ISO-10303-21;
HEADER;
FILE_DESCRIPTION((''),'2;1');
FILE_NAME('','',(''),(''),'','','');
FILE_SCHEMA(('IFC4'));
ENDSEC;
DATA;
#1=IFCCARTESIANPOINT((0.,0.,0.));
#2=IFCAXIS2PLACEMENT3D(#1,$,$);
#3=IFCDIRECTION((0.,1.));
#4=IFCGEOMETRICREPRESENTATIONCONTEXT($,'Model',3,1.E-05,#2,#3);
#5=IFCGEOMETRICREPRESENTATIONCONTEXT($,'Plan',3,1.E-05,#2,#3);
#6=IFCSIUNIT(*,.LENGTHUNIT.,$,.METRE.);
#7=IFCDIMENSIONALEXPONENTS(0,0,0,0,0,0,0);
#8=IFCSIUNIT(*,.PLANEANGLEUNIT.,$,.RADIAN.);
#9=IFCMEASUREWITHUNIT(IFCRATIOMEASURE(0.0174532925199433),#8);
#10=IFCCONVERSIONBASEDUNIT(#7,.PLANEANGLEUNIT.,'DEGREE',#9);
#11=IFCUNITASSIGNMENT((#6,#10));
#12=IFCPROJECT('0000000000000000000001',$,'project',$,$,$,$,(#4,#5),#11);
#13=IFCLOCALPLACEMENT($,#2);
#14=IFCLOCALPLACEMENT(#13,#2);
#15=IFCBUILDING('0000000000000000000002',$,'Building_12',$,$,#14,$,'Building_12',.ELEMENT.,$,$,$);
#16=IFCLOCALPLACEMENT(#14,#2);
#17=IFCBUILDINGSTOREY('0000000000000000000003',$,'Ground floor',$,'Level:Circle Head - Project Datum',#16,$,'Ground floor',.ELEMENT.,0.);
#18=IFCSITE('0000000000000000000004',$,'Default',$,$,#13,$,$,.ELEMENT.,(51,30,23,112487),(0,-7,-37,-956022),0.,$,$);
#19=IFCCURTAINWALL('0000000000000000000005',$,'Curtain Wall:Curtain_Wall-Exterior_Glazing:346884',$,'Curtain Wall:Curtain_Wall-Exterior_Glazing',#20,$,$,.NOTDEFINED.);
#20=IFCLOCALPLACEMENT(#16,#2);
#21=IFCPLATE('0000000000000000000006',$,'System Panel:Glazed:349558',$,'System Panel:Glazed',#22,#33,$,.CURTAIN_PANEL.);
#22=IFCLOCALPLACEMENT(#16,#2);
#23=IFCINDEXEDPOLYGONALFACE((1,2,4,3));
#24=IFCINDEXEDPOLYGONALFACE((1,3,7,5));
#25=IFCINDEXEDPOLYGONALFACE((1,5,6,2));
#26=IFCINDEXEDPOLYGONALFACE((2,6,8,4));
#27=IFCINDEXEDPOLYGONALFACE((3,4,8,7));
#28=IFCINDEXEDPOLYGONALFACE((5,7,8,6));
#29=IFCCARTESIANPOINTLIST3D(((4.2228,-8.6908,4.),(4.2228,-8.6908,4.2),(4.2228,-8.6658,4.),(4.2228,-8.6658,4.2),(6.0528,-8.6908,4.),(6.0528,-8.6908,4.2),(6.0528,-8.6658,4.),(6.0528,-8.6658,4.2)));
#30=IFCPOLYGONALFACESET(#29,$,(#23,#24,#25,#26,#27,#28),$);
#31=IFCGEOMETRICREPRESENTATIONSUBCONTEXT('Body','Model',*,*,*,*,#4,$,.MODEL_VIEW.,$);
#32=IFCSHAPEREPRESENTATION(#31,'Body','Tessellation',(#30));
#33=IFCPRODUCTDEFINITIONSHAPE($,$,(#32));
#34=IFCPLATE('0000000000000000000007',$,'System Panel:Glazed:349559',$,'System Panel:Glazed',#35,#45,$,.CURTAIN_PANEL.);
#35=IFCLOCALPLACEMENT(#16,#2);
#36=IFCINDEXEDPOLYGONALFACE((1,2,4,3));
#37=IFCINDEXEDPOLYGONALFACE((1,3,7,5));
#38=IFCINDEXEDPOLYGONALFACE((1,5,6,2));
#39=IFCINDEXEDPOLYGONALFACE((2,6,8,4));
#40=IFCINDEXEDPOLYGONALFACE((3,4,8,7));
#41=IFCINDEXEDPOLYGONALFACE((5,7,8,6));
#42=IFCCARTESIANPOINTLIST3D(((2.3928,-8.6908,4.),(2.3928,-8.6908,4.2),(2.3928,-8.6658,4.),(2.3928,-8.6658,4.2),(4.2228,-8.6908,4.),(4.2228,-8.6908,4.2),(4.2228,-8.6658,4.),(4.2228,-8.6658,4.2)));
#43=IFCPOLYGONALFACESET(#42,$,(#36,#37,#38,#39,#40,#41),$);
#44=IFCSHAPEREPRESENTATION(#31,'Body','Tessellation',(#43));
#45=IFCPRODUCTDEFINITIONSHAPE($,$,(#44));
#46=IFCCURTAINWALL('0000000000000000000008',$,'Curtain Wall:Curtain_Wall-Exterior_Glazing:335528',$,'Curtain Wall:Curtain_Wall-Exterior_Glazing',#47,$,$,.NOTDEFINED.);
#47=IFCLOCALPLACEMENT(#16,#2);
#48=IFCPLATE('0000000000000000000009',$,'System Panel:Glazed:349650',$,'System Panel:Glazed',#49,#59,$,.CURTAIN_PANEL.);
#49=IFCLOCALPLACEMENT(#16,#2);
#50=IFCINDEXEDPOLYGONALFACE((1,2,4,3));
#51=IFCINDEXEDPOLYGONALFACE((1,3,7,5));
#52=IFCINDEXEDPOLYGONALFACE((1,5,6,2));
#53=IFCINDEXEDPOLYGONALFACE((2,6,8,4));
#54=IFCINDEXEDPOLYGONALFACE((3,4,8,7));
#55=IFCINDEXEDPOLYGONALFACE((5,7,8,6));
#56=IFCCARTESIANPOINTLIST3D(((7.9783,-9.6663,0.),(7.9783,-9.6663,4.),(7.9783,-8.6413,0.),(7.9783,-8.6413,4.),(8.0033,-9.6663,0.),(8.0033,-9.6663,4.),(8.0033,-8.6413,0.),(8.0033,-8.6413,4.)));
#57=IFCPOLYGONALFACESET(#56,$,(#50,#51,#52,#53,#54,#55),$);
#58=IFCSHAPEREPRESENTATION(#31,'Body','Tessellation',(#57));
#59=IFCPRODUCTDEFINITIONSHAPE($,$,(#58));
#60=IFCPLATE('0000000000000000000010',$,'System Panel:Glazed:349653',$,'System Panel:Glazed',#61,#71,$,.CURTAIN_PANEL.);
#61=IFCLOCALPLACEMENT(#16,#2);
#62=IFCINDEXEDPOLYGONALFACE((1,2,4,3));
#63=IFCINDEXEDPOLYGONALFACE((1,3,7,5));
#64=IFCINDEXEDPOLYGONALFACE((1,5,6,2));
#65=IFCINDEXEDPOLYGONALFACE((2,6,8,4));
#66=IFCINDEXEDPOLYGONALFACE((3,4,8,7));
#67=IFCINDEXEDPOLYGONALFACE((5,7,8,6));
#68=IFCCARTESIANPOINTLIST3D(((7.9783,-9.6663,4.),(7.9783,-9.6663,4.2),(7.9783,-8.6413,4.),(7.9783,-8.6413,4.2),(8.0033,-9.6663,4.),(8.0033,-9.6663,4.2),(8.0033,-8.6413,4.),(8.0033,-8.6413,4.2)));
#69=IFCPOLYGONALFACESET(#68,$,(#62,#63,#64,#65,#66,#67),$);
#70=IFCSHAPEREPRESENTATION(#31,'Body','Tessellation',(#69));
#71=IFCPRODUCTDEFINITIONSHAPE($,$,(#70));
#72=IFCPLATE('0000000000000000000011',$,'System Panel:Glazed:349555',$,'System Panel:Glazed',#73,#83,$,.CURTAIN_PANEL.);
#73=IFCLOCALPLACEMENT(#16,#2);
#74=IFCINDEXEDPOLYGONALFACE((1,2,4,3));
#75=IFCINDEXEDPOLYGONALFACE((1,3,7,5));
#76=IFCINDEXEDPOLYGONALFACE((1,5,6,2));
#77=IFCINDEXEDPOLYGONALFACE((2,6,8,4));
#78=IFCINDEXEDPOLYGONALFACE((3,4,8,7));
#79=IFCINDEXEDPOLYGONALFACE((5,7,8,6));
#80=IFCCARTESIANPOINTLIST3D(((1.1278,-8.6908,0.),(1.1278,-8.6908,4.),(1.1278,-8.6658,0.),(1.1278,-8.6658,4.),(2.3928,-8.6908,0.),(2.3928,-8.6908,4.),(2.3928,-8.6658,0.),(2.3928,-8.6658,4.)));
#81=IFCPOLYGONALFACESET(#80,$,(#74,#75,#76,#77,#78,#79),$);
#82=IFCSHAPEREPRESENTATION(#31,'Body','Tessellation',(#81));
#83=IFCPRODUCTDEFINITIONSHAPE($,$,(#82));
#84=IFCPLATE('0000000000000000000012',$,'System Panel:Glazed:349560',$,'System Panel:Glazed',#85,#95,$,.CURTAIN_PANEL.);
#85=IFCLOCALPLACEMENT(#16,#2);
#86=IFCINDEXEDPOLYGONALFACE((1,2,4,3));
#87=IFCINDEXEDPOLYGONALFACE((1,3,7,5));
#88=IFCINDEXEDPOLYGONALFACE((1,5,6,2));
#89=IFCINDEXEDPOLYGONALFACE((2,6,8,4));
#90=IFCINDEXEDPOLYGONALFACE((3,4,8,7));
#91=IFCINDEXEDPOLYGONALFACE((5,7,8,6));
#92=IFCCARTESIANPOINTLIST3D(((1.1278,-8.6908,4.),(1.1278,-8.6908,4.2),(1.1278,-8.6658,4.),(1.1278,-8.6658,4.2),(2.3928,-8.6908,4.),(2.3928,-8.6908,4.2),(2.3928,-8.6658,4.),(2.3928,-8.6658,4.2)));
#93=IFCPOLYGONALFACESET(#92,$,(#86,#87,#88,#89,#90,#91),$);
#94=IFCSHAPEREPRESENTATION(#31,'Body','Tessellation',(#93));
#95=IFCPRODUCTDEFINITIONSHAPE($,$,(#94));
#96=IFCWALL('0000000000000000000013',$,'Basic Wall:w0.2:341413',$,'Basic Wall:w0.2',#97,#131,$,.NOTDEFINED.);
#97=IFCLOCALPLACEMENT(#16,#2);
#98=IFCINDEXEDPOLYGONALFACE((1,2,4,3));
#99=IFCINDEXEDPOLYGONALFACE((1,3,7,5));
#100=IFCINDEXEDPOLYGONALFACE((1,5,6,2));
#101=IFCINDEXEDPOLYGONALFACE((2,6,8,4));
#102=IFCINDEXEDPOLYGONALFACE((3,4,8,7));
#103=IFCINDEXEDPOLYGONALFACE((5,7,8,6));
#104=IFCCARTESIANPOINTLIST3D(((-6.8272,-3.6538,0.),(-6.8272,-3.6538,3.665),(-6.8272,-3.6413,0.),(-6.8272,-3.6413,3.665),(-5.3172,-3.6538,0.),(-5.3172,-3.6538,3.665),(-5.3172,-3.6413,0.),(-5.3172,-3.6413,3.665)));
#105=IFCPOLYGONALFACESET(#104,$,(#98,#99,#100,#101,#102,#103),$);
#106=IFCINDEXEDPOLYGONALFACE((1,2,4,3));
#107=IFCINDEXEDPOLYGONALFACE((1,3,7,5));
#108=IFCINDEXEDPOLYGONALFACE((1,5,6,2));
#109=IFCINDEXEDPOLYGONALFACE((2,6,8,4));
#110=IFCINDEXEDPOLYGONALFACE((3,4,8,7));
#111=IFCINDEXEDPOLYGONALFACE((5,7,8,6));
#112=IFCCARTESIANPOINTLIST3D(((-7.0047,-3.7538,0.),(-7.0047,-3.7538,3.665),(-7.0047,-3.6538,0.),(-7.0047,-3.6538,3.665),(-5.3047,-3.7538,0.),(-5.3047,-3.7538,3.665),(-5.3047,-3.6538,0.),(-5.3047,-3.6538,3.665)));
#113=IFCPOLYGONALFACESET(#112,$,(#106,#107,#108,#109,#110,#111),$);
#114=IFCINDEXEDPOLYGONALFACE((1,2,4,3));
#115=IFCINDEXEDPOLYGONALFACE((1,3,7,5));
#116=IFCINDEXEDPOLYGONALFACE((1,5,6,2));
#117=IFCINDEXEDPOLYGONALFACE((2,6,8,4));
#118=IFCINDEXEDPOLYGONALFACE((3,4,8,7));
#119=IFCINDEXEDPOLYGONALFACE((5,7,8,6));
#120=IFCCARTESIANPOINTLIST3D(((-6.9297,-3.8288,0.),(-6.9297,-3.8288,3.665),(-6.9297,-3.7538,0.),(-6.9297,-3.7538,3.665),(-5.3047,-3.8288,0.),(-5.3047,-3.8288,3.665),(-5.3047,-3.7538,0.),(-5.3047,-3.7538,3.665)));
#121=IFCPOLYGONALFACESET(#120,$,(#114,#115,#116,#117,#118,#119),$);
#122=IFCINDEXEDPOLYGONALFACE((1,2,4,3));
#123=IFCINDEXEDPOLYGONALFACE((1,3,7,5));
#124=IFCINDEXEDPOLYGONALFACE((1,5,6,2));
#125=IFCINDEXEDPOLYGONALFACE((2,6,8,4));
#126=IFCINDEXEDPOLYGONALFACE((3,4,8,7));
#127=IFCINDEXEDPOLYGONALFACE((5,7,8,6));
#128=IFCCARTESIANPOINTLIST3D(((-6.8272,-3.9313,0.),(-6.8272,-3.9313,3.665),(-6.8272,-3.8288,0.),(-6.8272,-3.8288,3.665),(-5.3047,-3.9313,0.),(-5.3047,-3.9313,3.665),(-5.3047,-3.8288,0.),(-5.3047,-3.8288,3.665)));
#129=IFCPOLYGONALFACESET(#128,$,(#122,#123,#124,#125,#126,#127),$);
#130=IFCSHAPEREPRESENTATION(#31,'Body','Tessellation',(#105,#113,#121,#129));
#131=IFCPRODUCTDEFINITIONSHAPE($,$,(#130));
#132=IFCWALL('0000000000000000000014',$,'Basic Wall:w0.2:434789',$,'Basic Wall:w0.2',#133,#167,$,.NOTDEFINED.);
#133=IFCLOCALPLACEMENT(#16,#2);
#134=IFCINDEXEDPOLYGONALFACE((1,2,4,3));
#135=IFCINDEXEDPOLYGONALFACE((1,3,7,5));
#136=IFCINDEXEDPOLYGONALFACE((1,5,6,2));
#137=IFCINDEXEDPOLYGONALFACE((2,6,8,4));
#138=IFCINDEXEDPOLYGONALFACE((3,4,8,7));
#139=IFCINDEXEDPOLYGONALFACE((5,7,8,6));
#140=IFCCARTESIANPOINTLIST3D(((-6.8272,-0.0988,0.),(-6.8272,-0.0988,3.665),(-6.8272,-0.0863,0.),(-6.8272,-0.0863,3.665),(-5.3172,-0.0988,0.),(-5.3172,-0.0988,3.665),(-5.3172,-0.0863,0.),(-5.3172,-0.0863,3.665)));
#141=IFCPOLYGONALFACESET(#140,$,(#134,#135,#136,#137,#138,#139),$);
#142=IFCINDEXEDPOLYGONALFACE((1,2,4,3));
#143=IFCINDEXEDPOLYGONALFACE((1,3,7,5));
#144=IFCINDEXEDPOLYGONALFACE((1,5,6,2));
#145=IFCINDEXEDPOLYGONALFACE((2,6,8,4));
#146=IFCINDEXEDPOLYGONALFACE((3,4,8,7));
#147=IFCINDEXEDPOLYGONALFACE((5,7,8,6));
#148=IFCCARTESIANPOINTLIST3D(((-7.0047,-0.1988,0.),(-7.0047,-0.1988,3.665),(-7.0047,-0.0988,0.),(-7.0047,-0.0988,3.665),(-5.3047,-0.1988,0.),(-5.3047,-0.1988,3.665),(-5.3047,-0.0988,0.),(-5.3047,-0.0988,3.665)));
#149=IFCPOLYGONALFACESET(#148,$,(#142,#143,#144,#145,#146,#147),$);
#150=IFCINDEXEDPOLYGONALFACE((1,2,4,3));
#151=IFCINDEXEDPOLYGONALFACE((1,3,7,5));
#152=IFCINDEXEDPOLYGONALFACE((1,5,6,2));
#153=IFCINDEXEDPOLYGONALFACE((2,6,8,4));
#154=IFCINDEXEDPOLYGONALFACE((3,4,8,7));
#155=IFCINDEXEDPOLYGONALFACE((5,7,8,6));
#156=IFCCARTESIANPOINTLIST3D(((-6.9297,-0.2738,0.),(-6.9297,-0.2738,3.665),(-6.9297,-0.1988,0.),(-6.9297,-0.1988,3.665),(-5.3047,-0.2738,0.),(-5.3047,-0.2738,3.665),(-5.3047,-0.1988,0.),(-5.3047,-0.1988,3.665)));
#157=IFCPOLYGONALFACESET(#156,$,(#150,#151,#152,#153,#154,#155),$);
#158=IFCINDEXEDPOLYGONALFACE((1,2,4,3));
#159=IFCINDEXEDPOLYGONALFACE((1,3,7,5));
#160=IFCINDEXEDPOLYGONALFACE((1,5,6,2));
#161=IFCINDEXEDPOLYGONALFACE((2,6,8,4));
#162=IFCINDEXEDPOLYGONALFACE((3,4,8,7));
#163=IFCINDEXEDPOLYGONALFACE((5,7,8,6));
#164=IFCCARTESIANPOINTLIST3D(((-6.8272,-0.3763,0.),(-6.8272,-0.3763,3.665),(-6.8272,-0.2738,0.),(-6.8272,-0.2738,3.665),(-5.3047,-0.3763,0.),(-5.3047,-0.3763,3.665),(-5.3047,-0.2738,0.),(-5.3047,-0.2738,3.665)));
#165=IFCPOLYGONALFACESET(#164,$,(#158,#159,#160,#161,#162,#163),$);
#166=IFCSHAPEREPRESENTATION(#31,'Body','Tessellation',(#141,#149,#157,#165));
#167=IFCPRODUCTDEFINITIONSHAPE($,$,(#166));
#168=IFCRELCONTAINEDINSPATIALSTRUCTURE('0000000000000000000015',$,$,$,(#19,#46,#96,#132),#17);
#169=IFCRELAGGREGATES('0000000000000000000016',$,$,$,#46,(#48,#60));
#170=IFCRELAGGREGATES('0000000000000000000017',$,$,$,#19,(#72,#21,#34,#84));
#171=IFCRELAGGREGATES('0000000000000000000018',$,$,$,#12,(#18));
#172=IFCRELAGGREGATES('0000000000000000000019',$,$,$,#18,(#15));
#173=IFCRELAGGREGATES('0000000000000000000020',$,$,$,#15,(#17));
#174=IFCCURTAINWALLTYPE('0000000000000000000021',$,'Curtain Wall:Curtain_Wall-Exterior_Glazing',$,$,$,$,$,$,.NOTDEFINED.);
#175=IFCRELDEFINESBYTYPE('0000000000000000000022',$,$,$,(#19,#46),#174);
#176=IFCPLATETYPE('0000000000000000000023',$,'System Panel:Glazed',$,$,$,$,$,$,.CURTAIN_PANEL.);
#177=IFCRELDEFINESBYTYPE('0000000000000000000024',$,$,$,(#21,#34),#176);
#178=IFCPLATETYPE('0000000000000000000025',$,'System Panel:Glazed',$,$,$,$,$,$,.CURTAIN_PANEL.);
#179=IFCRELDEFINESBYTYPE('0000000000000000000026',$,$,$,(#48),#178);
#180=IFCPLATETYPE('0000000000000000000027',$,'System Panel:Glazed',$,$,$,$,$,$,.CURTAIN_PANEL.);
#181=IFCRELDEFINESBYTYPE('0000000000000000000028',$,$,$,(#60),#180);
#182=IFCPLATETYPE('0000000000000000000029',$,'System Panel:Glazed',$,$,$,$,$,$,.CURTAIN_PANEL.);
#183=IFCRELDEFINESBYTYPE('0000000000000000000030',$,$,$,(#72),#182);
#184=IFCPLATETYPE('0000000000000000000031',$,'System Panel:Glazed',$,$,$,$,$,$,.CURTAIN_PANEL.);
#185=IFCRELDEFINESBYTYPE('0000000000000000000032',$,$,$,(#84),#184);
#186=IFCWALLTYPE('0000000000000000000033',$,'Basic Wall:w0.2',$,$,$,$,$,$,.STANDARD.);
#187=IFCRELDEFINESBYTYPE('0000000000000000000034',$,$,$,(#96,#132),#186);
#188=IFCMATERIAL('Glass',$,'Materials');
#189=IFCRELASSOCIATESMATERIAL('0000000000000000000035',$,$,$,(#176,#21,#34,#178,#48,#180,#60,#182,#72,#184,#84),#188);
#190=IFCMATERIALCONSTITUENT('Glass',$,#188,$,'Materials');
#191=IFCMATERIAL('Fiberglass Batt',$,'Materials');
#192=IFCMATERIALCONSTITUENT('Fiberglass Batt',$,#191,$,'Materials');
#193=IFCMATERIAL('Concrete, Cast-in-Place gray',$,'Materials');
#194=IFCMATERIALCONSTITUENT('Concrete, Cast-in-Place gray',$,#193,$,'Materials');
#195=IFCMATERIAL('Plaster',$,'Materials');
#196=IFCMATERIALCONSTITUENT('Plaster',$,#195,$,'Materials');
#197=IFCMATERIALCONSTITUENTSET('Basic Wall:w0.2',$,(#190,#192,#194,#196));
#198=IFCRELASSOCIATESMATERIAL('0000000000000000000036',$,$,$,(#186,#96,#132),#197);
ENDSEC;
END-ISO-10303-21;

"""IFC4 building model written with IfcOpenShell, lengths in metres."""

from ifc_helpers import new_model, entity, si_unit, converted_unit, direction, frame, origin, place, context, subcontext, project, spatial, indexed_curve, outline, extrude, source, transform, mapped, material, constituent, constituent_set, type_object, type_shapes, element, aggregate, save


model = new_model("IFC4")

# Units and contexts
model_context = context("Model", 3, precision=1e-05, world=origin(), true_north=direction((0.0, 1.0)))
plan_context = context("Plan", 3, precision=1e-05, world=origin(), true_north=direction((0.0, 1.0)))
body_context = subcontext(model_context, "Body", "Model", "MODEL_VIEW")
ifc_project = project(units=[si_unit("LENGTHUNIT", "METRE"), converted_unit("PLANEANGLEUNIT", "DEGREE", entity("IfcRatioMeasure", 0.0174532925199433), si_unit("PLANEANGLEUNIT", "RADIAN"), dimensions=[0, 0, 0, 0, 0, 0, 0])], contexts=[model_context, plan_context])

# Site, building, storey
site_placement = place(None, origin())
site = spatial("IfcSite", under=ifc_project, at=site_placement, Name="Default", CompositionType="ELEMENT", RefLatitude=(51, 30, 23, 112487), RefLongitude=(0, -7, -37, -956022), RefElevation=0.0)
building_placement = place(site_placement, origin())
building = spatial("IfcBuilding", under=site, at=building_placement, Name="Building_12", LongName="Building_12", CompositionType="ELEMENT")
storey_placement = place(building_placement, origin())
storey = spatial("IfcBuildingStorey", under=building, at=storey_placement, Name="Ground floor", ObjectType="Level:Circle Head - Project Datum", LongName="Ground floor", CompositionType="ELEMENT", Elevation=0.0)

# Shared definitions
ifc_material_1 = material(Name="Plaster", Category="Materials")
ifc_material_2 = material(Name="Glass", Category="Materials")

# Shared definitions
ifc_material_3 = material(Name="Concrete, Cast-in-Place gray", Category="Materials")

# Curtain walls, plates
curtain_wall_type = type_object("IfcCurtainWallType", Name="Curtain Wall:Curtain_Wall-Exterior_Glazing", PredefinedType="NOTDEFINED")
curtain_wall_1_placement = place(storey_placement, origin())
curtain_wall_1 = element("IfcCurtainWall", 1, at=curtain_wall_1_placement, inside=storey, type_object=curtain_wall_type, Name="Curtain Wall:Curtain_Wall-Exterior_Glazing:346884", ObjectType="Curtain Wall:Curtain_Wall-Exterior_Glazing", PredefinedType="NOTDEFINED")
plate_type_1 = type_object("IfcPlateType", Name="System Panel:Glazed", PredefinedType="CURTAIN_PANEL", material=ifc_material_2)
shared_shape_1 = source(origin(), body_context, "Body", "SweptSolid", [
    extrude(outline(indexed_curve([(-0.0125, -0.915), (0.0125, -0.915), (0.0125, 0.915), (-0.0125, 0.915), (-0.0125, -0.915)], self_intersect=False)), frame((0.0, 0.037, 0.0), z_axis=(0.0, 0.0, 1.0), x_axis=(0.0, 1.0, 0.0)), (0.0, 0.0, 1.0), 0.2),
])
type_shapes(plate_type_1, [shared_shape_1])
plate_1_placement = place(curtain_wall_1_placement, frame((5.1378, -8.6413, 4.0), z_axis=(0.0, 0.0, 1.0), x_axis=(-1.0, 0.0, 0.0)))
plate_1 = element("IfcPlate", 2, at=plate_1_placement, type_object=plate_type_1, material=ifc_material_2, Name="System Panel:Glazed:349558", ObjectType="System Panel:Glazed", PredefinedType="CURTAIN_PANEL", context=body_context, shape_type="MappedRepresentation", body=[
    mapped(shared_shape_1, transform((0.0, 0.0, 0.0), scale=1.0)),
])
plate_2_placement = place(curtain_wall_1_placement, frame((3.3078, -8.6413, 4.0), z_axis=(0.0, 0.0, 1.0), x_axis=(-1.0, 0.0, 0.0)))
plate_2 = element("IfcPlate", 3, at=plate_2_placement, type_object=plate_type_1, material=ifc_material_2, Name="System Panel:Glazed:349559", ObjectType="System Panel:Glazed", PredefinedType="CURTAIN_PANEL", context=body_context, shape_type="MappedRepresentation", body=[
    mapped(shared_shape_1, transform((0.0, 0.0, 0.0), scale=1.0)),
])
curtain_wall_2_placement = place(storey_placement, origin())
curtain_wall_2 = element("IfcCurtainWall", 4, at=curtain_wall_2_placement, inside=storey, type_object=curtain_wall_type, Name="Curtain Wall:Curtain_Wall-Exterior_Glazing:335528", ObjectType="Curtain Wall:Curtain_Wall-Exterior_Glazing", PredefinedType="NOTDEFINED")
plate_type_2 = type_object("IfcPlateType", Name="System Panel:Glazed", PredefinedType="CURTAIN_PANEL", material=ifc_material_2)
shared_shape_2 = source(origin(), body_context, "Body", "SweptSolid", [
    extrude(outline(indexed_curve([(-0.0125, -0.5125), (0.0125, -0.5125), (0.0125, 0.5125), (-0.0125, 0.5125), (-0.0125, -0.5125)], self_intersect=False)), frame((0.0, 0.037, 0.0), z_axis=(0.0, 0.0, 1.0), x_axis=(0.0, 1.0, 0.0)), (0.0, 0.0, 1.0), 4.0),
])
type_shapes(plate_type_2, [shared_shape_2])
plate_3_placement = place(curtain_wall_2_placement, frame((8.0278, -9.1538, 0.0), z_axis=(0.0, 0.0, 1.0), x_axis=(0.0, 1.0, 0.0)))
plate_3 = element("IfcPlate", 5, at=plate_3_placement, type_object=plate_type_2, material=ifc_material_2, Name="System Panel:Glazed:349650", ObjectType="System Panel:Glazed", PredefinedType="CURTAIN_PANEL", context=body_context, shape_type="MappedRepresentation", body=[
    mapped(shared_shape_2, transform((0.0, 0.0, 0.0), scale=1.0)),
])
plate_type_3 = type_object("IfcPlateType", Name="System Panel:Glazed", PredefinedType="CURTAIN_PANEL", material=ifc_material_2)
shared_shape_3 = source(origin(), body_context, "Body", "SweptSolid", [
    extrude(outline(indexed_curve([(-0.0125, -0.5125), (0.0125, -0.5125), (0.0125, 0.5125), (-0.0125, 0.5125), (-0.0125, -0.5125)], self_intersect=False)), frame((0.0, 0.037, 0.0), z_axis=(0.0, 0.0, 1.0), x_axis=(0.0, 1.0, 0.0)), (0.0, 0.0, 1.0), 0.2),
])
type_shapes(plate_type_3, [shared_shape_3])
plate_4_placement = place(curtain_wall_2_placement, frame((8.0278, -9.1538, 4.0), z_axis=(0.0, 0.0, 1.0), x_axis=(0.0, 1.0, 0.0)))
plate_4 = element("IfcPlate", 6, at=plate_4_placement, type_object=plate_type_3, material=ifc_material_2, Name="System Panel:Glazed:349653", ObjectType="System Panel:Glazed", PredefinedType="CURTAIN_PANEL", context=body_context, shape_type="MappedRepresentation", body=[
    mapped(shared_shape_3, transform((0.0, 0.0, 0.0), scale=1.0)),
])
aggregate(curtain_wall_2, [plate_3, plate_4])

# Plates
plate_type_4 = type_object("IfcPlateType", Name="System Panel:Glazed", PredefinedType="CURTAIN_PANEL", material=ifc_material_2)
shared_shape_4 = source(origin(), body_context, "Body", "SweptSolid", [
    extrude(outline(indexed_curve([(-0.0125, -0.6325), (0.0125, -0.6325), (0.0125, 0.6325), (-0.0125, 0.6325), (-0.0125, -0.6325)], self_intersect=False)), frame((0.0, 0.037, 0.0), z_axis=(0.0, 0.0, 1.0), x_axis=(0.0, 1.0, 0.0)), (0.0, 0.0, 1.0), 4.0),
])
type_shapes(plate_type_4, [shared_shape_4])
plate_5_placement = place(curtain_wall_1_placement, frame((1.7603, -8.6413, 0.0), z_axis=(0.0, 0.0, 1.0), x_axis=(-1.0, 0.0, 0.0)))
plate_5 = element("IfcPlate", 7, at=plate_5_placement, type_object=plate_type_4, material=ifc_material_2, Name="System Panel:Glazed:349555", ObjectType="System Panel:Glazed", PredefinedType="CURTAIN_PANEL", context=body_context, shape_type="MappedRepresentation", body=[
    mapped(shared_shape_4, transform((0.0, 0.0, 0.0), scale=1.0)),
])
plate_type_5 = type_object("IfcPlateType", Name="System Panel:Glazed", PredefinedType="CURTAIN_PANEL", material=ifc_material_2)
shared_shape_5 = source(origin(), body_context, "Body", "SweptSolid", [
    extrude(outline(indexed_curve([(-0.0125, -0.6325), (0.0125, -0.6325), (0.0125, 0.6325), (-0.0125, 0.6325), (-0.0125, -0.6325)], self_intersect=False)), frame((0.0, 0.037, 0.0), z_axis=(0.0, 0.0, 1.0), x_axis=(0.0, 1.0, 0.0)), (0.0, 0.0, 1.0), 0.2),
])
type_shapes(plate_type_5, [shared_shape_5])
plate_6_placement = place(curtain_wall_1_placement, frame((1.7603, -8.6413, 4.0), z_axis=(0.0, 0.0, 1.0), x_axis=(-1.0, 0.0, 0.0)))
plate_6 = element("IfcPlate", 8, at=plate_6_placement, type_object=plate_type_5, material=ifc_material_2, Name="System Panel:Glazed:349560", ObjectType="System Panel:Glazed", PredefinedType="CURTAIN_PANEL", context=body_context, shape_type="MappedRepresentation", body=[
    mapped(shared_shape_5, transform((0.0, 0.0, 0.0), scale=1.0)),
])
aggregate(curtain_wall_1, [plate_5, plate_1, plate_2, plate_6])

# Wall
ifc_constituent_1 = constituent(ifc_material_2, Name="Glass", Category="Materials")
ifc_material_4 = material(Name="Fiberglass Batt", Category="Materials")
ifc_constituent_2 = constituent(ifc_material_4, Name="Fiberglass Batt", Category="Materials")
ifc_constituent_3 = constituent(ifc_material_3, Name="Concrete, Cast-in-Place gray", Category="Materials")
ifc_constituent_4 = constituent(ifc_material_1, Name="Plaster", Category="Materials")
ifc_constituent_set_1 = constituent_set(constituents=[ifc_constituent_1, ifc_constituent_2, ifc_constituent_3, ifc_constituent_4], Name="Basic Wall:w0.2")
wall_type = type_object("IfcWallType", Name="Basic Wall:w0.2", PredefinedType="STANDARD", material=ifc_constituent_set_1)
wall_1_placement = place(storey_placement, frame((-5.3172, -3.7863, 0.0), z_axis=(0.0, 0.0, 1.0), x_axis=(-1.0, 0.0, 0.0)))
element("IfcWall", 9, at=wall_1_placement, inside=storey, type_object=wall_type, material=ifc_constituent_set_1, Name="Basic Wall:w0.2:341413", ObjectType="Basic Wall:w0.2", PredefinedType="NOTDEFINED", context=body_context, shape_type="SweptSolid", body=[
    extrude(outline(indexed_curve([(-0.0063, -0.755), (0.0062, -0.755), (0.0063, 0.755), (-0.0062, 0.755), (-0.0063, -0.755)], self_intersect=False)), frame((0.755, -0.1388, 0.0), z_axis=(0.0, 0.0, 1.0), x_axis=(0.0, 1.0, 0.0)), (0.0, 0.0, 1.0), 3.665),
    extrude(outline(indexed_curve([(-0.85, -0.05), (0.85, -0.05), (0.85, 0.05), (-0.85, 0.05), (-0.85, -0.05)], self_intersect=False)), frame((0.8375, -0.0825, 0.0)), (0.0, 0.0, 1.0), 3.665),
    extrude(outline(indexed_curve([(-0.8125, -0.0375), (0.8125, -0.0375), (0.8125, 0.0375), (-0.8125, 0.0375), (-0.8125, -0.0375)], self_intersect=False)), frame((0.8, 0.005, 0.0)), (0.0, 0.0, 1.0), 3.665),
    extrude(outline(indexed_curve([(-0.0513, -0.7612), (0.0512, -0.7612), (0.0513, 0.7612), (-0.0512, 0.7612), (-0.0513, -0.7612)], self_intersect=False)), frame((0.7487, 0.0938, 0.0), z_axis=(0.0, 0.0, 1.0), x_axis=(0.0, -1.0, 0.0)), (0.0, 0.0, 1.0), 3.665),
])

# Wall
wall_2_placement = place(storey_placement, frame((-5.3172, -0.2313, 0.0), z_axis=(0.0, 0.0, 1.0), x_axis=(-1.0, 0.0, 0.0)))
element("IfcWall", 10, at=wall_2_placement, inside=storey, type_object=wall_type, material=ifc_constituent_set_1, Name="Basic Wall:w0.2:434789", ObjectType="Basic Wall:w0.2", PredefinedType="NOTDEFINED", context=body_context, shape_type="SweptSolid", body=[
    extrude(outline(indexed_curve([(-0.0063, -0.755), (0.0062, -0.755), (0.0063, 0.755), (-0.0062, 0.755), (-0.0063, -0.755)], self_intersect=False)), frame((0.755, -0.1388, 0.0), z_axis=(0.0, 0.0, 1.0), x_axis=(0.0, 1.0, 0.0)), (0.0, 0.0, 1.0), 3.665),
    extrude(outline(indexed_curve([(-0.85, -0.05), (0.85, -0.05), (0.85, 0.05), (-0.85, 0.05), (-0.85, -0.05)], self_intersect=False)), frame((0.8375, -0.0825, 0.0)), (0.0, 0.0, 1.0), 3.665),
    extrude(outline(indexed_curve([(-0.8125, -0.0375), (0.8125, -0.0375), (0.8125, 0.0375), (-0.8125, 0.0375), (-0.8125, -0.0375)], self_intersect=False)), frame((0.8, 0.005, 0.0)), (0.0, 0.0, 1.0), 3.665),
    extrude(outline(indexed_curve([(-0.0513, -0.7612), (0.0512, -0.7612), (0.0513, 0.7612), (-0.0512, 0.7612), (-0.0513, -0.7612)], self_intersect=False)), frame((0.7487, 0.0938, 0.0), z_axis=(0.0, 0.0, 1.0), x_axis=(0.0, -1.0, 0.0)), (0.0, 0.0, 1.0), 3.665),
])

save(model, "model.ifc")
